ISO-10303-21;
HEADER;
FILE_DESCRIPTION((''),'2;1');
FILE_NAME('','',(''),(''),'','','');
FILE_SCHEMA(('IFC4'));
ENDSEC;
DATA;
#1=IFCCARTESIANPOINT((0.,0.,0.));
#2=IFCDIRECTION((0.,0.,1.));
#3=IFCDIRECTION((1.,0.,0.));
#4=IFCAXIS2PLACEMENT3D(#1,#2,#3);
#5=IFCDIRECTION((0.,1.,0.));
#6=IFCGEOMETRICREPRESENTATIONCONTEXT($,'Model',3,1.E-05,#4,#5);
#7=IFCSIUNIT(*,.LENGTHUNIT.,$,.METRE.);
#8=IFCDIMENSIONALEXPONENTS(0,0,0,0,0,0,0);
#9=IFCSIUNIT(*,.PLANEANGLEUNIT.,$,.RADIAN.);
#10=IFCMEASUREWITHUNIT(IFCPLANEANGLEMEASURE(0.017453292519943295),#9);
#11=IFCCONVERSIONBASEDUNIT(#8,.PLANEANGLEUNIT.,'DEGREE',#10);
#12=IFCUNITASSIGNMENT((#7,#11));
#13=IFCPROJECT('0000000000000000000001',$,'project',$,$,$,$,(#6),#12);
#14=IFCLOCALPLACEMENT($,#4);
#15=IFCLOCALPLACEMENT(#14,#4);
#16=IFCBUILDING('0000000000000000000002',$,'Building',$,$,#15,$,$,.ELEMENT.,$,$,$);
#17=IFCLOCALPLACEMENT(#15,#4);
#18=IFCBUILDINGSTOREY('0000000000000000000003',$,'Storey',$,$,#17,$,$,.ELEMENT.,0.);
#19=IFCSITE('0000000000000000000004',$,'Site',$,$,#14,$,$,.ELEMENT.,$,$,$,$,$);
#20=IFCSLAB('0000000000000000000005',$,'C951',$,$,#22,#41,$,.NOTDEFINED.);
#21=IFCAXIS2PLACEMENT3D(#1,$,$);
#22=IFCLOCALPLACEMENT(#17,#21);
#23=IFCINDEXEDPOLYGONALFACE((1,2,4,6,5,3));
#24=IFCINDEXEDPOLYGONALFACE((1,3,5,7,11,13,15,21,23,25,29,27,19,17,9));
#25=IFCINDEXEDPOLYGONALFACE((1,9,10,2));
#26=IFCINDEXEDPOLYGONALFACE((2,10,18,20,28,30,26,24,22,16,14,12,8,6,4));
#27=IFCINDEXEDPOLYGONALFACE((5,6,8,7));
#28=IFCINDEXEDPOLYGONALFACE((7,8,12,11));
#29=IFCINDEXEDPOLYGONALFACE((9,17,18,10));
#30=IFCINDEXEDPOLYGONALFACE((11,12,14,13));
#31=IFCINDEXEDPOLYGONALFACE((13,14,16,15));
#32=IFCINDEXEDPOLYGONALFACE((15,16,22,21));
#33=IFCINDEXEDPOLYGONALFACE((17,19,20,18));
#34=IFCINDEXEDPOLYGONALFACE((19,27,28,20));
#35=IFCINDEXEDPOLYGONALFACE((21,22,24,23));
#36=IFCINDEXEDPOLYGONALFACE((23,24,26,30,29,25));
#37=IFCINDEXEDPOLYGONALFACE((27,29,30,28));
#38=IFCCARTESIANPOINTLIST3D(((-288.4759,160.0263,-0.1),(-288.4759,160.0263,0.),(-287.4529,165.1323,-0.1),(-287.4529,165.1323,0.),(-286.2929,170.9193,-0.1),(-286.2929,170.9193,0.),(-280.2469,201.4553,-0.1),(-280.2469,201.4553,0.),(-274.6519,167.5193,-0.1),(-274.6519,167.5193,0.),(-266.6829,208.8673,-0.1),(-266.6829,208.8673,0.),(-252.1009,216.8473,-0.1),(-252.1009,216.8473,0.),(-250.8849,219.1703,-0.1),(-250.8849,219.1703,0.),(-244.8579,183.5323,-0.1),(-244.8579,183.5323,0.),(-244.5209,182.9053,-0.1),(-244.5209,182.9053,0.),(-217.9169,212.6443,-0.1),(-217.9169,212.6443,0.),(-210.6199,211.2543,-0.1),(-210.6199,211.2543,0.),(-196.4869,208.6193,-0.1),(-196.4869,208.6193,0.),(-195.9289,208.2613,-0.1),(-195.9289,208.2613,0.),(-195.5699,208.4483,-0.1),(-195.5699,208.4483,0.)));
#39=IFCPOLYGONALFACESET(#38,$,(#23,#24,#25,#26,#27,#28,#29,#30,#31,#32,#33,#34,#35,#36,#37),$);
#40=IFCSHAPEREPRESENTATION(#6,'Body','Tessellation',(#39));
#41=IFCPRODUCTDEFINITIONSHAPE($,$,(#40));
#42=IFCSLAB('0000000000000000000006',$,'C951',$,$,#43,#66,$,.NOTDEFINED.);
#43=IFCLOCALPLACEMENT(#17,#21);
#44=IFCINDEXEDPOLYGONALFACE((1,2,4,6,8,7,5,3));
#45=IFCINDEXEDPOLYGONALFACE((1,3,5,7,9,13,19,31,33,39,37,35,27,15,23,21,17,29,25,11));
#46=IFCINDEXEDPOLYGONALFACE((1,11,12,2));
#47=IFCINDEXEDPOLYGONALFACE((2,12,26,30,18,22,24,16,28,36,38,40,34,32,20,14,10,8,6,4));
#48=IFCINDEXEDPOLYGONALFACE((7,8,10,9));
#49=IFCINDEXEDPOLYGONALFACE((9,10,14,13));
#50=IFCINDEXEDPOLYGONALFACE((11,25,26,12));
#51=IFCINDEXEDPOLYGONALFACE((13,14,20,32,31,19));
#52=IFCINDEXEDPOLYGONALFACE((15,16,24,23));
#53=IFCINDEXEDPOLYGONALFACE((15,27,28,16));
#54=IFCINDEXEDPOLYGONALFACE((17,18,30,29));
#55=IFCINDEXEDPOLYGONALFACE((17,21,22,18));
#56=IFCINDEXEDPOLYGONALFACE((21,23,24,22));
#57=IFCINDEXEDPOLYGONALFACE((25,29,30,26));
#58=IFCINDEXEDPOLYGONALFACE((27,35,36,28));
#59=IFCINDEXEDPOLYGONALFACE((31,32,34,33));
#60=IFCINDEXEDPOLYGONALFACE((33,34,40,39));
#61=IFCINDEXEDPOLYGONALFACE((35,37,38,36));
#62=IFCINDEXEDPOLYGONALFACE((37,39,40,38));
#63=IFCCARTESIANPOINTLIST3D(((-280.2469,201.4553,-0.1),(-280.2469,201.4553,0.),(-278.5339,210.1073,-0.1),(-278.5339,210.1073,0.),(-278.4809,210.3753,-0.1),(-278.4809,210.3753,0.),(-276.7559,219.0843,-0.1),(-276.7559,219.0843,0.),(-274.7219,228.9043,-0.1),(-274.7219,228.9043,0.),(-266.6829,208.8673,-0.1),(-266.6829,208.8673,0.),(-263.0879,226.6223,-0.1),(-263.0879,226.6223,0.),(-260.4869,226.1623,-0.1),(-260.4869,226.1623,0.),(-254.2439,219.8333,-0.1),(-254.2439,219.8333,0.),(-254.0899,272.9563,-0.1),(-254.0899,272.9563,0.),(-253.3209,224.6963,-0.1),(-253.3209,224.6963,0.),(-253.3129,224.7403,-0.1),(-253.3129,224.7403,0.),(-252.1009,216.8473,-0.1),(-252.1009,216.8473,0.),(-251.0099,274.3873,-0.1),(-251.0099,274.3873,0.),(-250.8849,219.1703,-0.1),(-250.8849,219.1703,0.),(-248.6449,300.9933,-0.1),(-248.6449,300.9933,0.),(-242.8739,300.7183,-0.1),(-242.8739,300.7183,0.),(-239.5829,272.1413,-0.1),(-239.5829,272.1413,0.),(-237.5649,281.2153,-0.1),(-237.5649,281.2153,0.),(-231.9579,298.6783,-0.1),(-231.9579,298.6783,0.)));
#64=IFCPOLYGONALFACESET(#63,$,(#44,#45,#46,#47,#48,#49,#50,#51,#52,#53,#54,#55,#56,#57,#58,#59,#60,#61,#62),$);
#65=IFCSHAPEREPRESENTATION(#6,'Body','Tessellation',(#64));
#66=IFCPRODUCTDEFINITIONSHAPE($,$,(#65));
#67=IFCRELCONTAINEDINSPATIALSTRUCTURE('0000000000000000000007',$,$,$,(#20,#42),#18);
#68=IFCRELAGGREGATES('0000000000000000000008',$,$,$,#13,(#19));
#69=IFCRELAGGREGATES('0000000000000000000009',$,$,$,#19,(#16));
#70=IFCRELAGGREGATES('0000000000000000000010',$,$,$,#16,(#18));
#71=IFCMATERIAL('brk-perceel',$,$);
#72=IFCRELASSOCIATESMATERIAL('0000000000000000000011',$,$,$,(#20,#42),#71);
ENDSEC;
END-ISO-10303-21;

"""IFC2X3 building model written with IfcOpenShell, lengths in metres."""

from ifc_helpers import new_model, entity, si_unit, converted_unit, direction, frame, origin_with_axes, place, context, project, spatial, polyline, outline, extrude, material, element, save


model = new_model("IFC2X3")

# Units and contexts
model_context = context("Model", 3, precision=1e-05, world=origin_with_axes(), true_north=direction((0.0, 1.0, 0.0)))
ifc_project = project(units=[si_unit("LENGTHUNIT", "METRE"), converted_unit("PLANEANGLEUNIT", "DEGREE", entity("IfcPlaneAngleMeasure", 0.017453292519943295), si_unit("PLANEANGLEUNIT", "RADIAN"), dimensions=[0, 0, 0, 0, 0, 0, 0])], contexts=[model_context])

# Site, building, storey
site_placement = place(None, origin_with_axes())
site = spatial("IfcSite", under=ifc_project, at=site_placement, Name="Site", CompositionType="ELEMENT")
building_placement = place(site_placement, origin_with_axes())
building = spatial("IfcBuilding", under=site, at=building_placement, Name="Building", CompositionType="ELEMENT")
storey_placement = place(building_placement, origin_with_axes())
storey = spatial("IfcBuildingStorey", under=building, at=storey_placement, Name="Storey", CompositionType="ELEMENT", Elevation=0.0)

# Slabs
ifc_material = material(Name="brk-perceel")
slab_1_placement = place(storey_placement, frame((0.0, 0.0, -0.1), z_axis=(0.0, 0.0, 1.0), x_axis=(1.0, 0.0, 0.0)))
element("IfcSlab", 1, at=slab_1_placement, inside=storey, material=ifc_material, Name="C951", PredefinedType="NOTDEFINED", context=model_context, shape_type="SweptSolid", body=[
    extrude(outline(polyline([(-244.5209, 182.9053), (-244.8579, 183.5323), (-274.6519, 167.5193), (-288.4759, 160.0263), (-287.4529, 165.1323), (-286.2929, 170.9193), (-280.2469, 201.4553), (-266.6829, 208.8673), (-252.1009, 216.8473), (-250.8849, 219.1703), (-217.9169, 212.6443), (-210.6199, 211.2543), (-196.4869, 208.6193), (-195.5699, 208.4483), (-195.9289, 208.2613), (-244.5209, 182.9053)])), origin_with_axes(), (0.0, 0.0, 1.0), 0.1),
])
slab_2_placement = place(storey_placement, frame((0.0, 0.0, -0.1), z_axis=(0.0, 0.0, 1.0), x_axis=(1.0, 0.0, 0.0)))
element("IfcSlab", 2, at=slab_2_placement, inside=storey, material=ifc_material, Name="C951", PredefinedType="NOTDEFINED", context=model_context, shape_type="SweptSolid", body=[
    extrude(outline(polyline([(-252.1009, 216.8473), (-266.6829, 208.8673), (-280.2469, 201.4553), (-278.5339, 210.1073), (-278.4809, 210.3753), (-276.7559, 219.0843), (-274.7219, 228.9043), (-263.0879, 226.6223), (-254.0899, 272.9563), (-248.6449, 300.9933), (-242.8739, 300.7183), (-231.9579, 298.6783), (-237.5649, 281.2153), (-239.5829, 272.1413), (-251.0099, 274.3873), (-260.4869, 226.1623), (-253.3129, 224.7403), (-253.3209, 224.6963), (-254.2439, 219.8333), (-250.8849, 219.1703), (-252.1009, 216.8473)])), origin_with_axes(), (0.0, 0.0, 1.0), 0.1),
])

save(model, "model.ifc")
